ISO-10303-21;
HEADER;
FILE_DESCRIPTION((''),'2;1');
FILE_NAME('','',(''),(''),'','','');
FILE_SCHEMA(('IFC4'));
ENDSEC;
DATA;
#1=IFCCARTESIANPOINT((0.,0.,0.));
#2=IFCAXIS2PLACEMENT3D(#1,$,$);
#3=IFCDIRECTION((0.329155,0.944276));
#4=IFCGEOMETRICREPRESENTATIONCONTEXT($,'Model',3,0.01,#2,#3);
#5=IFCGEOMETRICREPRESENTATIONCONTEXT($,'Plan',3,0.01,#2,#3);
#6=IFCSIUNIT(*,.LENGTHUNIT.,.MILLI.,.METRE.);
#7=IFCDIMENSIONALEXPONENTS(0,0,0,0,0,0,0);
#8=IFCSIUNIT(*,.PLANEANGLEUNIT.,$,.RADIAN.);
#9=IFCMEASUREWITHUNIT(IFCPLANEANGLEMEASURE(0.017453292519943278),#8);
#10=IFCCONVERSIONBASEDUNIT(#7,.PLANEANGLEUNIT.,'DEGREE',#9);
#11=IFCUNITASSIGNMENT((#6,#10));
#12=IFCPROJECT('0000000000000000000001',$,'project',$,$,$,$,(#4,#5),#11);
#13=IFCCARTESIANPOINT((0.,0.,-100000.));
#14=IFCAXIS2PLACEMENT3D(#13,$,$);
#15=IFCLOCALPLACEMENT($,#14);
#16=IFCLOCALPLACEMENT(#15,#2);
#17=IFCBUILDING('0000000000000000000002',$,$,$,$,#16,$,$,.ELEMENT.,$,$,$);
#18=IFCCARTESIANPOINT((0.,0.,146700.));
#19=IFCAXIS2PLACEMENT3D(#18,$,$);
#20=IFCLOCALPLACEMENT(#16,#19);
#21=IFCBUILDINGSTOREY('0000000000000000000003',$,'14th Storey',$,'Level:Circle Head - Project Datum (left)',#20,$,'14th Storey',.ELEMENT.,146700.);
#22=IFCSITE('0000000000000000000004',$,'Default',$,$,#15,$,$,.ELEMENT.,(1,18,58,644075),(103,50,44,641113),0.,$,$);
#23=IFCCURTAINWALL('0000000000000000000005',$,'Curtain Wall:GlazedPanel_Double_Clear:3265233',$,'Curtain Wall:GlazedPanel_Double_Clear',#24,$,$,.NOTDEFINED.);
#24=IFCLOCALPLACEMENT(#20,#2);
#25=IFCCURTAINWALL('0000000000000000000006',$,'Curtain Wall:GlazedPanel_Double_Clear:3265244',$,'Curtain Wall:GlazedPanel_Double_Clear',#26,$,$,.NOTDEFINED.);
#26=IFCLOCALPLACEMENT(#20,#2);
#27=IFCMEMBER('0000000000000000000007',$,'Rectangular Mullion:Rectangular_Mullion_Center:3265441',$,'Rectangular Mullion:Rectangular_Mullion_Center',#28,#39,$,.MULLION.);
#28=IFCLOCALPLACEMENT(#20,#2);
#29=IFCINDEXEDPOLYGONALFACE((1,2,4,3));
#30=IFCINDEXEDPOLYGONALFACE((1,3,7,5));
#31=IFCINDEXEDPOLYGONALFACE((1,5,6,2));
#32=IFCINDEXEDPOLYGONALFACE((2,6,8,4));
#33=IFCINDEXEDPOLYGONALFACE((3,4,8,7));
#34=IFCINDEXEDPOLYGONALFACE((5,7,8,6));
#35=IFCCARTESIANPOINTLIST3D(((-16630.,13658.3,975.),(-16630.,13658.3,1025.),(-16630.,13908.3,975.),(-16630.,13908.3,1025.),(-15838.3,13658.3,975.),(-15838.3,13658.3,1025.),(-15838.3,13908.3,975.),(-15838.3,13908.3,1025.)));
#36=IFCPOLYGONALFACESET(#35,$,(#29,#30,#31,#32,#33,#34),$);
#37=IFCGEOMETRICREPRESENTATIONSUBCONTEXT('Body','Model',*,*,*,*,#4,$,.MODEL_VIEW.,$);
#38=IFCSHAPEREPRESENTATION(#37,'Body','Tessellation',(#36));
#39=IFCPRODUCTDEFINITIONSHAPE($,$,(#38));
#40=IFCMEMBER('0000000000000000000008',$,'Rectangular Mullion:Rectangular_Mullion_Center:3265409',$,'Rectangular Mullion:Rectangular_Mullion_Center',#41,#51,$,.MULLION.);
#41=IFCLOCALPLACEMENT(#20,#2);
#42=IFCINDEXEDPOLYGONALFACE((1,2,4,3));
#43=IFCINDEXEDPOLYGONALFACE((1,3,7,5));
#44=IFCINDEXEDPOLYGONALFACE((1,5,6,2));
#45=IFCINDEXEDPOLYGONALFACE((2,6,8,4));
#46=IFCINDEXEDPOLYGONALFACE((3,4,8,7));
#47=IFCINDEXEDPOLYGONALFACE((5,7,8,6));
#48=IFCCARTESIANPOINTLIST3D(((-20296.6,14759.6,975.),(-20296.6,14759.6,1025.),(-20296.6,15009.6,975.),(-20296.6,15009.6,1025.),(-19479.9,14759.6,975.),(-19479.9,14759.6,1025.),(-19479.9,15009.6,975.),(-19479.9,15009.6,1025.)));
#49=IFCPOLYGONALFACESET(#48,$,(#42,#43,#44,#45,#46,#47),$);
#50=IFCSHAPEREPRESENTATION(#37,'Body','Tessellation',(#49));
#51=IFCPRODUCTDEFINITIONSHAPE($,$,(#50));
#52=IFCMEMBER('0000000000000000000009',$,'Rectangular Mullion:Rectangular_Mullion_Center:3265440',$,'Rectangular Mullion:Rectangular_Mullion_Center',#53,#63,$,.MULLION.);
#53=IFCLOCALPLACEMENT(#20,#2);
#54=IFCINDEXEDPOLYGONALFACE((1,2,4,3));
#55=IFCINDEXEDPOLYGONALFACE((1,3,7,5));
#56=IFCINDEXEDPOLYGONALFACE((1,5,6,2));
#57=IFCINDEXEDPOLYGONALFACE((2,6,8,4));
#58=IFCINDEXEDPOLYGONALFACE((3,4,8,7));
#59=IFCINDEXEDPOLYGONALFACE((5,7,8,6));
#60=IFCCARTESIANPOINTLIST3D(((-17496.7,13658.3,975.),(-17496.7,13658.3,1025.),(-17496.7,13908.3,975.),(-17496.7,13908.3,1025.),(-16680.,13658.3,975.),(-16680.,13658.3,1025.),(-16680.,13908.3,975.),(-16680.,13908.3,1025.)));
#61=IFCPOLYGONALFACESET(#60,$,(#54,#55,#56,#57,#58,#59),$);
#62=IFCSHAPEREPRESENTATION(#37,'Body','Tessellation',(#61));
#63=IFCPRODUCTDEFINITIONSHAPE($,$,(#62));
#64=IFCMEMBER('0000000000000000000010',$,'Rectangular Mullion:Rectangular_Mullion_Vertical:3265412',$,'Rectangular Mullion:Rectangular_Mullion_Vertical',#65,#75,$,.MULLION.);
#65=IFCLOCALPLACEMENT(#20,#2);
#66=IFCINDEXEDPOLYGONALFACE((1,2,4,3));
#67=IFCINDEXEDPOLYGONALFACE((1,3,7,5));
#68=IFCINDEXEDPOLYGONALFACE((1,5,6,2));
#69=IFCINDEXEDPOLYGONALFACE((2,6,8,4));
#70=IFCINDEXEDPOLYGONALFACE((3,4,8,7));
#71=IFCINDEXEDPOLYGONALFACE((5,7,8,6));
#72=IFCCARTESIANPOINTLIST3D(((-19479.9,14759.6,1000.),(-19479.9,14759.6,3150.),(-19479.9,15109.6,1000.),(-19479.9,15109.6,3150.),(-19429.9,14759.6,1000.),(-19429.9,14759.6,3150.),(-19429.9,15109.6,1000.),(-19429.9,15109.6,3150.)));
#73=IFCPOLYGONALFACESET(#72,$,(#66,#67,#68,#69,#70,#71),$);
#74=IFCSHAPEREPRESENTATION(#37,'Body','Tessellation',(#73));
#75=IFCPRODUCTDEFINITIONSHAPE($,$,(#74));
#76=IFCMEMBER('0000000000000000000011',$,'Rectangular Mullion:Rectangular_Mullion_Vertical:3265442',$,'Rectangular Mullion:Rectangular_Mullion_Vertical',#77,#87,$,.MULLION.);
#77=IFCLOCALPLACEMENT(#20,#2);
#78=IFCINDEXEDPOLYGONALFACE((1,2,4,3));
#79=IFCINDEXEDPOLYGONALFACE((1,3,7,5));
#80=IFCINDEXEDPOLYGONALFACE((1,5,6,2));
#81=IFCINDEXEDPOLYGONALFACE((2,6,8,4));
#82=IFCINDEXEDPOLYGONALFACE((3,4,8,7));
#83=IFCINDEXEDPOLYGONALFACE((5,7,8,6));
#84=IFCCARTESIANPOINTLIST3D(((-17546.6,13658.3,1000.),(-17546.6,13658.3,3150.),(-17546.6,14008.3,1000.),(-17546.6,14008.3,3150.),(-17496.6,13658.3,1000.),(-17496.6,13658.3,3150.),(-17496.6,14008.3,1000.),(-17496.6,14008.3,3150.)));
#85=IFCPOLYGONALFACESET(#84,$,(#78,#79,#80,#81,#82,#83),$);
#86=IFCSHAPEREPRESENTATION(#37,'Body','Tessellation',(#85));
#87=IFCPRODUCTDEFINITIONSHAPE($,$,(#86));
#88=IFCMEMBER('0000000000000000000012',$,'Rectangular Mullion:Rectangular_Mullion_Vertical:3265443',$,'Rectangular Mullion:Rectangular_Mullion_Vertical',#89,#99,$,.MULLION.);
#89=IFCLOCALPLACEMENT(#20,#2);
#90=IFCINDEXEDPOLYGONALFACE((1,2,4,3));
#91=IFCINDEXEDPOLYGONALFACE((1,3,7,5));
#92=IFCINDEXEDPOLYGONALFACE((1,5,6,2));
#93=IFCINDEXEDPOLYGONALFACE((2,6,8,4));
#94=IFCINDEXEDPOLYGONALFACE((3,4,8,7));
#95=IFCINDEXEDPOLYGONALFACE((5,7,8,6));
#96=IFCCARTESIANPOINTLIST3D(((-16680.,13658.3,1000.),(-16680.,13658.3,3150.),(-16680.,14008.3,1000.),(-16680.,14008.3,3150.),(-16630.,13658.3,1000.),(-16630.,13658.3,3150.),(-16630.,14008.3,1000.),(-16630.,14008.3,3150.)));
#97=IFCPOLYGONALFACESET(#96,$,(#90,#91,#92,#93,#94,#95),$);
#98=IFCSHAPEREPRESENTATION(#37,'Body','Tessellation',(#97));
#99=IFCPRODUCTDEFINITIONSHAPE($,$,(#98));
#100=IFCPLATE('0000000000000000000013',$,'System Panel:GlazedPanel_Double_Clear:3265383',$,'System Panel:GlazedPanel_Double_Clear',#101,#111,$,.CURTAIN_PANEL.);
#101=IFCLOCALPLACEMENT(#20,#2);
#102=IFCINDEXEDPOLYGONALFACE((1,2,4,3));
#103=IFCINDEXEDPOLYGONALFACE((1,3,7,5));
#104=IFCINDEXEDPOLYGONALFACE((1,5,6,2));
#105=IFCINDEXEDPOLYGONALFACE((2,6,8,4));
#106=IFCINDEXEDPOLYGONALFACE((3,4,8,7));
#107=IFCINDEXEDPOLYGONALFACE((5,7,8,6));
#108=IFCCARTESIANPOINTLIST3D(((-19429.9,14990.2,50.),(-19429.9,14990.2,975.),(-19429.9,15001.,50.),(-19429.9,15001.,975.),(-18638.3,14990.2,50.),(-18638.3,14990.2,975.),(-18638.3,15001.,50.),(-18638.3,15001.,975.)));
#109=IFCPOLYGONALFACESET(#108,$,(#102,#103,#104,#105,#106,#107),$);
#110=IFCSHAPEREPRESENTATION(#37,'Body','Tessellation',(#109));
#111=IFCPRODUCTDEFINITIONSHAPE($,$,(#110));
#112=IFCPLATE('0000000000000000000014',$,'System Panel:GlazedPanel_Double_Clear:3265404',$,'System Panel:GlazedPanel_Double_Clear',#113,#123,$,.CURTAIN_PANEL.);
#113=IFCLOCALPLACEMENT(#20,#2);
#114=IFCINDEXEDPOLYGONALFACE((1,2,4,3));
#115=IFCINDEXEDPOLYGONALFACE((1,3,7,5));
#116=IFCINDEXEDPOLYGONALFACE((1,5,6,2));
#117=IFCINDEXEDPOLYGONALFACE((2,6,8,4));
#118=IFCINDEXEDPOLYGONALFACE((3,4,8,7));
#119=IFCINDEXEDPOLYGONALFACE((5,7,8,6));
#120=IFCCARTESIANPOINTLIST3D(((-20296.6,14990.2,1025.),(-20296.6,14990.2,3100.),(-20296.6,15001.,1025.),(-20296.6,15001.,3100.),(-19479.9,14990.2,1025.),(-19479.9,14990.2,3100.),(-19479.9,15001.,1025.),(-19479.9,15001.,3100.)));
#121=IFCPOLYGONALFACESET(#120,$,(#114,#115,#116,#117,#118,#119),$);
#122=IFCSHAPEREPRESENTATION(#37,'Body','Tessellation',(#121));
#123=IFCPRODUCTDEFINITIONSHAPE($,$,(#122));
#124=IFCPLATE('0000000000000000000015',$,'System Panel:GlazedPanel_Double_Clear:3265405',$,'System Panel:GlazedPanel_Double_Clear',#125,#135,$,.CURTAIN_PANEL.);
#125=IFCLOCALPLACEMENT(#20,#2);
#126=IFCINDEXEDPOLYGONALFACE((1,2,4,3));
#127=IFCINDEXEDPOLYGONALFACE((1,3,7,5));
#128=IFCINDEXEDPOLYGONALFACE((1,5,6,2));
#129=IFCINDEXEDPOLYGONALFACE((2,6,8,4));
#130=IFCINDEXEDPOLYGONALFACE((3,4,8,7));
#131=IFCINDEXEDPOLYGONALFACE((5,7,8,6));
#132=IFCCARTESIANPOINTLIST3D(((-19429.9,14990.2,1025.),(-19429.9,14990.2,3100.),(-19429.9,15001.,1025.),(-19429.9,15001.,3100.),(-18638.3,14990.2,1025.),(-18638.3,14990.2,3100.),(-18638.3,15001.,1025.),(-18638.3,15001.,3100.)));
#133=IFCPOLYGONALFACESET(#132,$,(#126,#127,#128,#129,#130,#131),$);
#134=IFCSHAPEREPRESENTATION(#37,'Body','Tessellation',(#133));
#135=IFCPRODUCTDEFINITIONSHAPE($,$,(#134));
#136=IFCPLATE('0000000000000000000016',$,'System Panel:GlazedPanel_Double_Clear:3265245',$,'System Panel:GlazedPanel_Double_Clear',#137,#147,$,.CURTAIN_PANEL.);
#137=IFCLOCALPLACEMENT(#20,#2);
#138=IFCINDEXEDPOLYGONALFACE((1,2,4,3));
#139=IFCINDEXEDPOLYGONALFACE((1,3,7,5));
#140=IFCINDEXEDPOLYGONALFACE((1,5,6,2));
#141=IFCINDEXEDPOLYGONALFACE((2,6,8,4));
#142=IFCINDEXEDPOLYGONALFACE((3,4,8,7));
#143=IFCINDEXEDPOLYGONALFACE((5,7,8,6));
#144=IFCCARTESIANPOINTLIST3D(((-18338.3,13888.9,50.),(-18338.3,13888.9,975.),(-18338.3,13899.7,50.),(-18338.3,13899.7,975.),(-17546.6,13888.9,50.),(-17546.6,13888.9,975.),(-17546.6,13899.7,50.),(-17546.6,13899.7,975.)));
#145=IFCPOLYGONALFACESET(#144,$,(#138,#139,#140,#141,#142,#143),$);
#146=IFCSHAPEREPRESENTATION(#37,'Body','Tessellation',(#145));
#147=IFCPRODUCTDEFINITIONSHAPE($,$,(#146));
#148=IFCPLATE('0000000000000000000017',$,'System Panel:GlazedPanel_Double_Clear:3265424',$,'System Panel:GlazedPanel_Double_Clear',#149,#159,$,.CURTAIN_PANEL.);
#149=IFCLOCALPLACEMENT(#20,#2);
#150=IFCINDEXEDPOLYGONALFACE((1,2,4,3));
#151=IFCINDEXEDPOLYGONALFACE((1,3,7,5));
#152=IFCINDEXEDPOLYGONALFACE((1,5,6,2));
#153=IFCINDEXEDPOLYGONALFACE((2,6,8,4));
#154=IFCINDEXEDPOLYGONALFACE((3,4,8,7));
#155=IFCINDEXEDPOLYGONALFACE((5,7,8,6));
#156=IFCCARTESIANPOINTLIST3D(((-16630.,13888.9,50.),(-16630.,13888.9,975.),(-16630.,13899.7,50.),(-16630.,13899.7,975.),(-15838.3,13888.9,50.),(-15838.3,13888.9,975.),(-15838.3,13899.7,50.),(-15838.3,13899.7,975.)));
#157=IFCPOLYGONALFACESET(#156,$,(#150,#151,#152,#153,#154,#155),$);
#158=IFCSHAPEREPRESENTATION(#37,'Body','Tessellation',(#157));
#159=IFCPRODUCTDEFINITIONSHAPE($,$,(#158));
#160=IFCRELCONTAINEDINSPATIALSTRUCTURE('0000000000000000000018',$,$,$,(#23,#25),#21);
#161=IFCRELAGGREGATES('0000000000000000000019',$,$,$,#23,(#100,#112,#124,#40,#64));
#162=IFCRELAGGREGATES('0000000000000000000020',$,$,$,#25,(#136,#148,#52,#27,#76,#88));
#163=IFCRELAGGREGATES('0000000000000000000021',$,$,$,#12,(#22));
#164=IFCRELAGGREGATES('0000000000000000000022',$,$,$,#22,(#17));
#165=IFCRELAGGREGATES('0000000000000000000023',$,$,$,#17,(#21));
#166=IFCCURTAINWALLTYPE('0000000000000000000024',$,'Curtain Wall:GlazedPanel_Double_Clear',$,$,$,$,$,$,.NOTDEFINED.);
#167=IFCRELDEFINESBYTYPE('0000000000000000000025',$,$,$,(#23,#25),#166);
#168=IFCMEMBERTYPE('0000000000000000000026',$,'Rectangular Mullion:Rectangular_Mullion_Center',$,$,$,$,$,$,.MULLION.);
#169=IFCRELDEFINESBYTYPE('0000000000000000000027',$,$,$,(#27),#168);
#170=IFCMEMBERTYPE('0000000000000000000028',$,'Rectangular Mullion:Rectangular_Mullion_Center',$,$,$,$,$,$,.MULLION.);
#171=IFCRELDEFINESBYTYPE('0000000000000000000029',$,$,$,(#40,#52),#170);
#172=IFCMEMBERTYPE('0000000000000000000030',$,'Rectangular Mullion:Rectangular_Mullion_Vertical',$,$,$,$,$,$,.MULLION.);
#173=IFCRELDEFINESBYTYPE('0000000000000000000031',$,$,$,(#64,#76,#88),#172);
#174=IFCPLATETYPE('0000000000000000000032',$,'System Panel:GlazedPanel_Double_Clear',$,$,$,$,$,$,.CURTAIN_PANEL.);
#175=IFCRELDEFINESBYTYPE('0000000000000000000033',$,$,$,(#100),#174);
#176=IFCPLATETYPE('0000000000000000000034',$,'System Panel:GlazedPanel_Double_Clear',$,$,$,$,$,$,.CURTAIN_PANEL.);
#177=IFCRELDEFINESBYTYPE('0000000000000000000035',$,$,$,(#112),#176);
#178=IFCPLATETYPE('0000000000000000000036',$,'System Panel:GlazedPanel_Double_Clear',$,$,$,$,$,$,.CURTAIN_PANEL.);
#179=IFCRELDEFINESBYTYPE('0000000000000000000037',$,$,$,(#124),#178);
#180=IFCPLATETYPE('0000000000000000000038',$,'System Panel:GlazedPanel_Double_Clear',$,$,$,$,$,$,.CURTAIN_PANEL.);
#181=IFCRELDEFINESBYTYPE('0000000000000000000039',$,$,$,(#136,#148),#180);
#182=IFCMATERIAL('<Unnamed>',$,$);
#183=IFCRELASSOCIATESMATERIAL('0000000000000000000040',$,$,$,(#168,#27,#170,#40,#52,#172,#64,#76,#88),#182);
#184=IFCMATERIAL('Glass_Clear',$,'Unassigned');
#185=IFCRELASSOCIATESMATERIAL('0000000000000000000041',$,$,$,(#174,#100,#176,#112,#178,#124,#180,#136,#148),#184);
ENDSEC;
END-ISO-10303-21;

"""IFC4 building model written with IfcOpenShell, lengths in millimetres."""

from ifc_helpers import new_model, entity, si_unit, converted_unit, direction, frame, origin, place, context, subcontext, project, spatial, indexed_curve, outline, extrude, source, transform, mapped, material, type_object, type_shapes, element, aggregate, save


model = new_model("IFC4")

# Units and contexts
model_context = context("Model", 3, precision=0.01, world=origin(), true_north=direction((0.329155, 0.944276)))
plan_context = context("Plan", 3, precision=0.01, world=origin(), true_north=direction((0.329155, 0.944276)))
body_context = subcontext(model_context, "Body", "Model", "MODEL_VIEW")
ifc_project = project(units=[si_unit("LENGTHUNIT", "METRE", prefix="MILLI"), converted_unit("PLANEANGLEUNIT", "DEGREE", entity("IfcPlaneAngleMeasure", 0.017453292519943278), si_unit("PLANEANGLEUNIT", "RADIAN"), dimensions=[0, 0, 0, 0, 0, 0, 0])], contexts=[model_context, plan_context])

# Site, building, storey
site_placement = place(None, frame((0.0, 0.0, -100000.0)))
site = spatial("IfcSite", under=ifc_project, at=site_placement, Name="Default", CompositionType="ELEMENT", RefLatitude=(1, 18, 58, 644075), RefLongitude=(103, 50, 44, 641113), RefElevation=0.0)
building_placement = place(site_placement, origin())
building = spatial("IfcBuilding", under=site, at=building_placement, CompositionType="ELEMENT")
storey_placement = place(building_placement, frame((0.0, 0.0, 146700.0)))
storey = spatial("IfcBuildingStorey", under=building, at=storey_placement, Name="14th Storey", ObjectType="Level:Circle Head - Project Datum (left)", LongName="14th Storey", CompositionType="ELEMENT", Elevation=146700.0)

# Curtain wall
curtain_wall_type = type_object("IfcCurtainWallType", Name="Curtain Wall:GlazedPanel_Double_Clear", PredefinedType="NOTDEFINED")
curtain_wall_1_placement = place(storey_placement, frame((0.0, 0.0, -146700.0)))
curtain_wall_1 = element("IfcCurtainWall", 1, at=curtain_wall_1_placement, inside=storey, type_object=curtain_wall_type, Name="Curtain Wall:GlazedPanel_Double_Clear:3265233", ObjectType="Curtain Wall:GlazedPanel_Double_Clear", PredefinedType="NOTDEFINED")
ifc_material_1 = material(Name="<Unnamed>")

# Curtain wall
curtain_wall_2_placement = place(storey_placement, frame((0.0, 0.0, -146700.0)))
curtain_wall_2 = element("IfcCurtainWall", 2, at=curtain_wall_2_placement, inside=storey, type_object=curtain_wall_type, Name="Curtain Wall:GlazedPanel_Double_Clear:3265244", ObjectType="Curtain Wall:GlazedPanel_Double_Clear", PredefinedType="NOTDEFINED")

# Members
member_type_1 = type_object("IfcMemberType", Name="Rectangular Mullion:Rectangular_Mullion_Center", PredefinedType="MULLION", material=ifc_material_1)
shared_shape_1 = source(origin(), body_context, "Body", "SweptSolid", [
    extrude(outline(indexed_curve([(-25.0, -125.0), (25.0, -125.0), (25.0, 125.0), (-25.0, 125.0), (-25.0, -125.0)], self_intersect=False)), frame((0.0, 0.0, -791.7), z_axis=(0.0, 0.0, 1.0), x_axis=(-1.0, 0.0, 0.0)), (0.0, 0.0, 1.0), 791.7),
])
type_shapes(member_type_1, [shared_shape_1])
member_1_placement = place(curtain_wall_2_placement, frame((-15838.3, 13783.3, 147700.0), z_axis=(1.0, 0.0, 0.0), x_axis=(0.0, 0.0, 1.0)))
member_1 = element("IfcMember", 3, at=member_1_placement, type_object=member_type_1, material=ifc_material_1, Name="Rectangular Mullion:Rectangular_Mullion_Center:3265441", ObjectType="Rectangular Mullion:Rectangular_Mullion_Center", PredefinedType="MULLION", context=body_context, shape_type="MappedRepresentation", body=[
    mapped(shared_shape_1, transform((0.0, 0.0, 0.0), scale=1.0)),
])
member_type_2 = type_object("IfcMemberType", Name="Rectangular Mullion:Rectangular_Mullion_Center", PredefinedType="MULLION", material=ifc_material_1)
shared_shape_2 = source(origin(), body_context, "Body", "SweptSolid", [
    extrude(outline(indexed_curve([(-25.0, -125.0), (25.0, -125.0), (25.0, 125.0), (-25.0, 125.0), (-25.0, -125.0)], self_intersect=False)), frame((0.0, 0.0, -816.7), z_axis=(0.0, 0.0, 1.0), x_axis=(-1.0, 0.0, 0.0)), (0.0, 0.0, 1.0), 816.7),
])
type_shapes(member_type_2, [shared_shape_2])
member_2_placement = place(curtain_wall_1_placement, frame((-19479.9, 14884.6, 147700.0), z_axis=(1.0, 0.0, 0.0), x_axis=(0.0, 0.0, 1.0)))
member_2 = element("IfcMember", 4, at=member_2_placement, type_object=member_type_2, material=ifc_material_1, Name="Rectangular Mullion:Rectangular_Mullion_Center:3265409", ObjectType="Rectangular Mullion:Rectangular_Mullion_Center", PredefinedType="MULLION", context=body_context, shape_type="MappedRepresentation", body=[
    mapped(shared_shape_2, transform((0.0, 0.0, 0.0), scale=1.0)),
])
member_3_placement = place(curtain_wall_2_placement, frame((-16680.0, 13783.3, 147700.0), z_axis=(1.0, 0.0, 0.0), x_axis=(0.0, 0.0, 1.0)))
member_3 = element("IfcMember", 5, at=member_3_placement, type_object=member_type_2, material=ifc_material_1, Name="Rectangular Mullion:Rectangular_Mullion_Center:3265440", ObjectType="Rectangular Mullion:Rectangular_Mullion_Center", PredefinedType="MULLION", context=body_context, shape_type="MappedRepresentation", body=[
    mapped(shared_shape_2, transform((0.0, 0.0, 0.0), scale=1.0)),
])
member_type_3 = type_object("IfcMemberType", Name="Rectangular Mullion:Rectangular_Mullion_Vertical", PredefinedType="MULLION", material=ifc_material_1)
shared_shape_3 = source(origin(), body_context, "Body", "SweptSolid", [
    extrude(outline(indexed_curve([(-25.0, -175.0), (25.0, -175.0), (25.0, 175.0), (-25.0, 175.0), (-25.0, -175.0)], self_intersect=False)), frame((0.0, -50.0, -2150.0), z_axis=(0.0, 0.0, 1.0), x_axis=(-1.0, 0.0, 0.0)), (0.0, 0.0, 1.0), 2150.0),
])
type_shapes(member_type_3, [shared_shape_3])
member_4_placement = place(curtain_wall_1_placement, frame((-19454.9, 14884.6, 147700.0), z_axis=(0.0, 0.0, -1.0), x_axis=(1.0, 0.0, 0.0)))
member_4 = element("IfcMember", 6, at=member_4_placement, type_object=member_type_3, material=ifc_material_1, Name="Rectangular Mullion:Rectangular_Mullion_Vertical:3265412", ObjectType="Rectangular Mullion:Rectangular_Mullion_Vertical", PredefinedType="MULLION", context=body_context, shape_type="MappedRepresentation", body=[
    mapped(shared_shape_3, transform((0.0, 0.0, 0.0), scale=1.0)),
])
member_5_placement = place(curtain_wall_2_placement, frame((-17521.6, 13783.3, 147700.0), z_axis=(0.0, 0.0, -1.0), x_axis=(1.0, 0.0, 0.0)))
member_5 = element("IfcMember", 7, at=member_5_placement, type_object=member_type_3, material=ifc_material_1, Name="Rectangular Mullion:Rectangular_Mullion_Vertical:3265442", ObjectType="Rectangular Mullion:Rectangular_Mullion_Vertical", PredefinedType="MULLION", context=body_context, shape_type="MappedRepresentation", body=[
    mapped(shared_shape_3, transform((0.0, 0.0, 0.0), scale=1.0)),
])
member_6_placement = place(curtain_wall_2_placement, frame((-16655.0, 13783.3, 147700.0), z_axis=(0.0, 0.0, -1.0), x_axis=(1.0, 0.0, 0.0)))
member_6 = element("IfcMember", 8, at=member_6_placement, type_object=member_type_3, material=ifc_material_1, Name="Rectangular Mullion:Rectangular_Mullion_Vertical:3265443", ObjectType="Rectangular Mullion:Rectangular_Mullion_Vertical", PredefinedType="MULLION", context=body_context, shape_type="MappedRepresentation", body=[
    mapped(shared_shape_3, transform((0.0, 0.0, 0.0), scale=1.0)),
])

# Plates
ifc_material_2 = material(Name="Glass_Clear", Category="Unassigned")
plate_type_1 = type_object("IfcPlateType", Name="System Panel:GlazedPanel_Double_Clear", PredefinedType="CURTAIN_PANEL", material=ifc_material_2)
shared_shape_4 = source(origin(), body_context, "Body", "SweptSolid", [
    extrude(outline(indexed_curve([(-5.4, -395.8), (5.4, -395.8), (5.4, 395.8), (-5.4, 395.8), (-5.4, -395.8)], self_intersect=False)), frame((395.8, 5.4, 0.0), z_axis=(0.0, 0.0, 1.0), x_axis=(0.0, 1.0, 0.0)), (0.0, 0.0, 1.0), 925.0),
])
type_shapes(plate_type_1, [shared_shape_4])
plate_1_placement = place(curtain_wall_1_placement, frame((-19429.9, 14990.2, 146750.0)))
plate_1 = element("IfcPlate", 9, at=plate_1_placement, type_object=plate_type_1, material=ifc_material_2, Name="System Panel:GlazedPanel_Double_Clear:3265383", ObjectType="System Panel:GlazedPanel_Double_Clear", PredefinedType="CURTAIN_PANEL", context=body_context, shape_type="MappedRepresentation", body=[
    mapped(shared_shape_4, transform((0.0, 0.0, 0.0), scale=1.0)),
])
plate_type_2 = type_object("IfcPlateType", Name="System Panel:GlazedPanel_Double_Clear", PredefinedType="CURTAIN_PANEL", material=ifc_material_2)
shared_shape_5 = source(origin(), body_context, "Body", "SweptSolid", [
    extrude(outline(indexed_curve([(-5.4, -408.3), (5.4, -408.3), (5.4, 408.3), (-5.4, 408.3), (-5.4, -408.3)], self_intersect=False)), frame((408.3, 5.4, 0.0), z_axis=(0.0, 0.0, 1.0), x_axis=(0.0, 1.0, 0.0)), (0.0, 0.0, 1.0), 2075.0),
])
type_shapes(plate_type_2, [shared_shape_5])
plate_2_placement = place(curtain_wall_1_placement, frame((-20296.6, 14990.2, 147725.0)))
plate_2 = element("IfcPlate", 10, at=plate_2_placement, type_object=plate_type_2, material=ifc_material_2, Name="System Panel:GlazedPanel_Double_Clear:3265404", ObjectType="System Panel:GlazedPanel_Double_Clear", PredefinedType="CURTAIN_PANEL", context=body_context, shape_type="MappedRepresentation", body=[
    mapped(shared_shape_5, transform((0.0, 0.0, 0.0), scale=1.0)),
])
plate_type_3 = type_object("IfcPlateType", Name="System Panel:GlazedPanel_Double_Clear", PredefinedType="CURTAIN_PANEL", material=ifc_material_2)
shared_shape_6 = source(origin(), body_context, "Body", "SweptSolid", [
    extrude(outline(indexed_curve([(-5.4, -395.8), (5.4, -395.8), (5.4, 395.8), (-5.4, 395.8), (-5.4, -395.8)], self_intersect=False)), frame((395.8, 5.4, 0.0), z_axis=(0.0, 0.0, 1.0), x_axis=(0.0, 1.0, 0.0)), (0.0, 0.0, 1.0), 2075.0),
])
type_shapes(plate_type_3, [shared_shape_6])
plate_3_placement = place(curtain_wall_1_placement, frame((-19429.9, 14990.2, 147725.0)))
plate_3 = element("IfcPlate", 11, at=plate_3_placement, type_object=plate_type_3, material=ifc_material_2, Name="System Panel:GlazedPanel_Double_Clear:3265405", ObjectType="System Panel:GlazedPanel_Double_Clear", PredefinedType="CURTAIN_PANEL", context=body_context, shape_type="MappedRepresentation", body=[
    mapped(shared_shape_6, transform((0.0, 0.0, 0.0), scale=1.0)),
])
aggregate(curtain_wall_1, [plate_1, plate_2, plate_3, member_2, member_4])
plate_type_4 = type_object("IfcPlateType", Name="System Panel:GlazedPanel_Double_Clear", PredefinedType="CURTAIN_PANEL", material=ifc_material_2)
shared_shape_7 = source(origin(), body_context, "Body", "SweptSolid", [
    extrude(outline(indexed_curve([(-5.4, -395.8), (5.4, -395.8), (5.4, 395.8), (-5.4, 395.8), (-5.4, -395.8)], self_intersect=False)), frame((395.8, 5.4, 0.0), z_axis=(0.0, 0.0, 1.0), x_axis=(0.0, 1.0, 0.0)), (0.0, 0.0, 1.0), 925.0),
])
type_shapes(plate_type_4, [shared_shape_7])
plate_4_placement = place(curtain_wall_2_placement, frame((-18338.3, 13888.9, 146750.0)))
plate_4 = element("IfcPlate", 12, at=plate_4_placement, type_object=plate_type_4, material=ifc_material_2, Name="System Panel:GlazedPanel_Double_Clear:3265245", ObjectType="System Panel:GlazedPanel_Double_Clear", PredefinedType="CURTAIN_PANEL", context=body_context, shape_type="MappedRepresentation", body=[
    mapped(shared_shape_7, transform((0.0, 0.0, 0.0), scale=1.0)),
])
plate_5_placement = place(curtain_wall_2_placement, frame((-16630.0, 13888.9, 146750.0)))
plate_5 = element("IfcPlate", 13, at=plate_5_placement, type_object=plate_type_4, material=ifc_material_2, Name="System Panel:GlazedPanel_Double_Clear:3265424", ObjectType="System Panel:GlazedPanel_Double_Clear", PredefinedType="CURTAIN_PANEL", context=body_context, shape_type="MappedRepresentation", body=[
    mapped(shared_shape_7, transform((0.0, 0.0, 0.0), scale=1.0)),
])
aggregate(curtain_wall_2, [plate_4, plate_5, member_3, member_1, member_5, member_6])

save(model, "model.ifc")
